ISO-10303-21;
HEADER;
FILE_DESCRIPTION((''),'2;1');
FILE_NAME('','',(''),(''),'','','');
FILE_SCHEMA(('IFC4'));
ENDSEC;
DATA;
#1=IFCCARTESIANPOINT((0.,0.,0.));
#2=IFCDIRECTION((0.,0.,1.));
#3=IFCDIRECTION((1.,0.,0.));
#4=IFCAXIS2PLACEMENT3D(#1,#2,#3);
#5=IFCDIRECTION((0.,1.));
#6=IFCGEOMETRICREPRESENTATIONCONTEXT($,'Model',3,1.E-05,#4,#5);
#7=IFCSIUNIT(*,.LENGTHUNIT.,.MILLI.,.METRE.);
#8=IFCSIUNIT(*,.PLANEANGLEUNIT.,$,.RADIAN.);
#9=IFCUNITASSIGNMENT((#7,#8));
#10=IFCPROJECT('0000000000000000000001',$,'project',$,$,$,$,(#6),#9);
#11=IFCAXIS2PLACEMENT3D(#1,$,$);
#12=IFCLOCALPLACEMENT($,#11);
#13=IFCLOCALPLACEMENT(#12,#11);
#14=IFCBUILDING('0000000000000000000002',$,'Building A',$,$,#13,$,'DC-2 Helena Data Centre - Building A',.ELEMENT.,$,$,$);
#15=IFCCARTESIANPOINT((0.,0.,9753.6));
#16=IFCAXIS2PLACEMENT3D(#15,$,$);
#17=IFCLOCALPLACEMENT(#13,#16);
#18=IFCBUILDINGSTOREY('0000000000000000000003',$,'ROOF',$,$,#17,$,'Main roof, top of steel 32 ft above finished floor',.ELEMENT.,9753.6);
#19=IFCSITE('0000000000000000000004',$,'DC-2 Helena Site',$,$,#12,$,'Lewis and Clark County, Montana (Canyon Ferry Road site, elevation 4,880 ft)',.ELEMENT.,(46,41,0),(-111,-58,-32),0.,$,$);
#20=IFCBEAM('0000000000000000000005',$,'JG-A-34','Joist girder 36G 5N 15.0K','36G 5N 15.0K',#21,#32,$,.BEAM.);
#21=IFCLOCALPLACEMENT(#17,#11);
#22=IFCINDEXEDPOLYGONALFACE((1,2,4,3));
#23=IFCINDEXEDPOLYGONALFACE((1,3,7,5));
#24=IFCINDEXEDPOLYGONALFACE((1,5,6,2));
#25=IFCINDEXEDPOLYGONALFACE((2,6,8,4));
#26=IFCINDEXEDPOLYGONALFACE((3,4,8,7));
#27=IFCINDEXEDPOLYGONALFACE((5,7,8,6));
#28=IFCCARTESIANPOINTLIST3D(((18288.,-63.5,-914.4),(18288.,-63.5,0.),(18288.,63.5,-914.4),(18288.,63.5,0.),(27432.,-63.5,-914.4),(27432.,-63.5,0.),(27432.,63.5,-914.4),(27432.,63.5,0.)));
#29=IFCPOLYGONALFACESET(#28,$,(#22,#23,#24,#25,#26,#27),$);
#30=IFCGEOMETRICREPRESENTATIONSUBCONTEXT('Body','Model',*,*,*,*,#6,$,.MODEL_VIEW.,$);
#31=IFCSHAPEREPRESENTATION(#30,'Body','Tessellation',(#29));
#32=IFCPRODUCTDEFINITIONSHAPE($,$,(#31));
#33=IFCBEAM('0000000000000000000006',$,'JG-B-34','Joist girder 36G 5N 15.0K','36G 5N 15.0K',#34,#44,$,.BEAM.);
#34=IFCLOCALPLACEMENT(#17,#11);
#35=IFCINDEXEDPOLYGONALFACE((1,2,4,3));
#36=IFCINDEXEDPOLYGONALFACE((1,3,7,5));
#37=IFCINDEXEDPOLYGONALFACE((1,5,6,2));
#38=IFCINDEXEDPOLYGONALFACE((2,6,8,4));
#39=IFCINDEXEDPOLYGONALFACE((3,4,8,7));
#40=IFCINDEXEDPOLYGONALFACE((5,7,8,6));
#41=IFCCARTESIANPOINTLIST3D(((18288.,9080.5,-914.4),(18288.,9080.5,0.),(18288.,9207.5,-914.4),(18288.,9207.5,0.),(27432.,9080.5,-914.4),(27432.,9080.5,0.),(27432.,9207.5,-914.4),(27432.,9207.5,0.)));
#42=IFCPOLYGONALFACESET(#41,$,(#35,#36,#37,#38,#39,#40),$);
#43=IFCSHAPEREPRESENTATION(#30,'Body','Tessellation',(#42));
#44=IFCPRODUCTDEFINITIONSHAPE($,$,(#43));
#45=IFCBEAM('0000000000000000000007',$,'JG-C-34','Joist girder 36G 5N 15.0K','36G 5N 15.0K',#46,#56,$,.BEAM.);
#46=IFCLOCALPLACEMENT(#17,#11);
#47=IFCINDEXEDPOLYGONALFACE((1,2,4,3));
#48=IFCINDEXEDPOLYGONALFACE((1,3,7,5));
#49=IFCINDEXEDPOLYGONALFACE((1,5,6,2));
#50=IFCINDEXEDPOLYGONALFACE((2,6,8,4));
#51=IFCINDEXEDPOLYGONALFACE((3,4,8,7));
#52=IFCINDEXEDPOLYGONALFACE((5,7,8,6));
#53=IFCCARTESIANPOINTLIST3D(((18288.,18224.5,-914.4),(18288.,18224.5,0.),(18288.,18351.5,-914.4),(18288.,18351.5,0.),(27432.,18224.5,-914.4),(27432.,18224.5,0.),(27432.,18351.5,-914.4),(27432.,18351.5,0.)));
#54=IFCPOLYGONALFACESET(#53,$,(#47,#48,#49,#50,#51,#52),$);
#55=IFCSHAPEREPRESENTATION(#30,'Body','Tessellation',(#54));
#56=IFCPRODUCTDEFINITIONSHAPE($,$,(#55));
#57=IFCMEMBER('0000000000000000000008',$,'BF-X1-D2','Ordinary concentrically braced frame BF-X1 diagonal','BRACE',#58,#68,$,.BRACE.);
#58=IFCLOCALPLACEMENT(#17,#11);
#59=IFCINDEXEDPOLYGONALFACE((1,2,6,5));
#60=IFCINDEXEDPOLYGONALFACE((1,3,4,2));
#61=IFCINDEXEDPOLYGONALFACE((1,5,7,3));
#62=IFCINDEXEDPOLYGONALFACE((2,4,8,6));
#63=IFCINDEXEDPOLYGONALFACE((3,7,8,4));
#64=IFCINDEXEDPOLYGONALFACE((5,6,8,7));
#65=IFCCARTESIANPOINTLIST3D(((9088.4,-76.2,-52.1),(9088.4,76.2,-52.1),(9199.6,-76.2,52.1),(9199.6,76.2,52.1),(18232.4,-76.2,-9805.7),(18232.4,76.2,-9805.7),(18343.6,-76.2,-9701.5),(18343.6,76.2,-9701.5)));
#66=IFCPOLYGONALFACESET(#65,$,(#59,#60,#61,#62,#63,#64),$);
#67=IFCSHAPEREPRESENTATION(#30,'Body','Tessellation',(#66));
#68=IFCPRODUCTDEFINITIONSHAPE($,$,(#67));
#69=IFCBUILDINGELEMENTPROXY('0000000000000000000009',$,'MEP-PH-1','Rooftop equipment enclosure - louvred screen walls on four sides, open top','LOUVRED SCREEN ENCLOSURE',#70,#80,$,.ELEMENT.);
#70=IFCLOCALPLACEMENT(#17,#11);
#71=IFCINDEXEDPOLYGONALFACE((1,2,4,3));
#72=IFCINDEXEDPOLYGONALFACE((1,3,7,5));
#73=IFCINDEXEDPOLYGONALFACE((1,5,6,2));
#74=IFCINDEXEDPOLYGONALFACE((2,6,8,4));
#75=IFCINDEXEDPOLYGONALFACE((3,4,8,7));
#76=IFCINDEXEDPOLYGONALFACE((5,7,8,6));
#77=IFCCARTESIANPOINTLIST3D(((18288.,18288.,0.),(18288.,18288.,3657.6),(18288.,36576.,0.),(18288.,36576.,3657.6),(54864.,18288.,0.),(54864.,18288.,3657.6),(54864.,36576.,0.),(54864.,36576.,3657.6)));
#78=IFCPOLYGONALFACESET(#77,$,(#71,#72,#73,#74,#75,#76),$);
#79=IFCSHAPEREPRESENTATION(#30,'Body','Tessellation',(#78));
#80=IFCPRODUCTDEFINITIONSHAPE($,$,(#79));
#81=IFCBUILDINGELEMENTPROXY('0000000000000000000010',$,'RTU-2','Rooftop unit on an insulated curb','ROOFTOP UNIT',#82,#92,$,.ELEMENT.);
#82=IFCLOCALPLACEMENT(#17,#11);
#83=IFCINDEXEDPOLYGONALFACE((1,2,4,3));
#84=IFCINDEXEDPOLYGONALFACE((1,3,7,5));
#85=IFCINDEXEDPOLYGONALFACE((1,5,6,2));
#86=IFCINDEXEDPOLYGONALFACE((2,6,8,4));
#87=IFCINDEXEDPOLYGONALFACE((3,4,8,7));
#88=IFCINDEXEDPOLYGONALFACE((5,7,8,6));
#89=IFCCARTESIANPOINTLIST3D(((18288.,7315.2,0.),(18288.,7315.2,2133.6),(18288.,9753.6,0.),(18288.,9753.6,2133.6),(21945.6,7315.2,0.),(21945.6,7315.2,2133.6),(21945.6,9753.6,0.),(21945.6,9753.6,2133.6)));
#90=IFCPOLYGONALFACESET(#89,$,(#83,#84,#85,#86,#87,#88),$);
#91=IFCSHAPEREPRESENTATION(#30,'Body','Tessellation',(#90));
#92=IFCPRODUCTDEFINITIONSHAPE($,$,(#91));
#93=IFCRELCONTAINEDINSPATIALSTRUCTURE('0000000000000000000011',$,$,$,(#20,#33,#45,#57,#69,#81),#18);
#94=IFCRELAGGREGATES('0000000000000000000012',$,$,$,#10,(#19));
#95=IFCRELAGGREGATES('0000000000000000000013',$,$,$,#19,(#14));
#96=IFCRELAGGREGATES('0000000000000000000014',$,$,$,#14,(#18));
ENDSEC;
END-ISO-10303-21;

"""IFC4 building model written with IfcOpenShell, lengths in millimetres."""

from ifc_helpers import new_model, si_unit, direction, frame, origin, origin_with_axes, origin_2d, place, context, subcontext, project, spatial, polyline, rectangle, outline, extrude, element, save


model = new_model("IFC4")

# Units and contexts
model_context = context("Model", 3, precision=1e-05, world=origin_with_axes(), true_north=direction((0.0, 1.0)))
body_context = subcontext(model_context, "Body", "Model", "MODEL_VIEW")
ifc_project = project(units=[si_unit("LENGTHUNIT", "METRE", prefix="MILLI"), si_unit("PLANEANGLEUNIT", "RADIAN")], contexts=[model_context])

# Site, building, storey
site_placement = place(None, origin())
site = spatial("IfcSite", under=ifc_project, at=site_placement, Name="DC-2 Helena Site", LongName="Lewis and Clark County, Montana (Canyon Ferry Road site, elevation 4,880 ft)", CompositionType="ELEMENT", RefLatitude=(46, 41, 0), RefLongitude=(-111, -58, -32), RefElevation=0.0)
building_placement = place(site_placement, origin())
building = spatial("IfcBuilding", under=site, at=building_placement, Name="Building A", LongName="DC-2 Helena Data Centre - Building A", CompositionType="ELEMENT")
storey_placement = place(building_placement, frame((0.0, 0.0, 9753.6)))
storey = spatial("IfcBuildingStorey", under=building, at=storey_placement, Name="ROOF", LongName="Main roof, top of steel 32 ft above finished floor", CompositionType="ELEMENT", Elevation=9753.6)

# Shared definitions
placement_1 = place(storey_placement, frame((18288.0, 0.0, -9753.6)))

# Beams
placement_2 = place(storey_placement, frame((18288.0, 0.0, 0.0)))
placement_3 = place(storey_placement, frame((18288.0, 9144.0, 0.0)))
placement_4 = place(storey_placement, frame((18288.0, 18288.0, 0.0)))
element("IfcBeam", 1, at=placement_2, inside=storey, Name="JG-A-34", Description="Joist girder 36G 5N 15.0K", ObjectType="36G 5N 15.0K", PredefinedType="BEAM", context=body_context, shape_type="SweptSolid", body=[
    extrude(rectangle(XDim=127.0, YDim=914.4, at=origin_2d()), frame((0.0, 0.0, -457.2), z_axis=(1.0, 0.0, 0.0), x_axis=(0.0, 1.0, 0.0)), (0.0, 0.0, 1.0), 9144.0),
])
element("IfcBeam", 2, at=placement_3, inside=storey, Name="JG-B-34", Description="Joist girder 36G 5N 15.0K", ObjectType="36G 5N 15.0K", PredefinedType="BEAM", context=body_context, shape_type="SweptSolid", body=[
    extrude(rectangle(XDim=127.0, YDim=914.4, at=origin_2d()), frame((0.0, 0.0, -457.2), z_axis=(1.0, 0.0, 0.0), x_axis=(0.0, 1.0, 0.0)), (0.0, 0.0, 1.0), 9144.0),
])
element("IfcBeam", 3, at=placement_4, inside=storey, Name="JG-C-34", Description="Joist girder 36G 5N 15.0K", ObjectType="36G 5N 15.0K", PredefinedType="BEAM", context=body_context, shape_type="SweptSolid", body=[
    extrude(rectangle(XDim=127.0, YDim=914.4, at=origin_2d()), frame((0.0, 0.0, -457.2), z_axis=(1.0, 0.0, 0.0), x_axis=(0.0, 1.0, 0.0)), (0.0, 0.0, 1.0), 9144.0),
])

# Member
element("IfcMember", 4, at=placement_1, inside=storey, Name="BF-X1-D2", Description="Ordinary concentrically braced frame BF-X1 diagonal", ObjectType="BRACE", PredefinedType="BRACE", context=body_context, shape_type="SweptSolid", body=[
    extrude(rectangle(XDim=152.4, YDim=152.4, at=origin_2d()), frame((0.0, 0.0, 0.0), z_axis=(-0.683941, 0.0, 0.729537), x_axis=(0.0, 1.0, 0.0)), (0.0, 0.0, 1.0), 13369.6),
])

# Building element proxies
element("IfcBuildingElementProxy", 5, at=placement_4, inside=storey, Name="MEP-PH-1", Description="Rooftop equipment enclosure - louvred screen walls on four sides, open top", ObjectType="LOUVRED SCREEN ENCLOSURE", PredefinedType="ELEMENT", context=body_context, shape_type="SweptSolid", body=[
    extrude(outline(polyline([(0.0, 0.0), (36576.0, 0.0), (36576.0, 18288.0), (0.0, 18288.0), (0.0, 0.0)])), origin(), (0.0, 0.0, 1.0), 3657.6),
])
proxy_1_placement = place(storey_placement, frame((20116.8, 8534.4, 0.0)))
element("IfcBuildingElementProxy", 6, at=proxy_1_placement, inside=storey, Name="RTU-2", Description="Rooftop unit on an insulated curb", ObjectType="ROOFTOP UNIT", PredefinedType="ELEMENT", context=body_context, shape_type="SweptSolid", body=[
    extrude(rectangle(XDim=3657.6, YDim=2438.4, at=origin_2d()), origin(), (0.0, 0.0, 1.0), 2133.6),
])

save(model, "model.ifc")
